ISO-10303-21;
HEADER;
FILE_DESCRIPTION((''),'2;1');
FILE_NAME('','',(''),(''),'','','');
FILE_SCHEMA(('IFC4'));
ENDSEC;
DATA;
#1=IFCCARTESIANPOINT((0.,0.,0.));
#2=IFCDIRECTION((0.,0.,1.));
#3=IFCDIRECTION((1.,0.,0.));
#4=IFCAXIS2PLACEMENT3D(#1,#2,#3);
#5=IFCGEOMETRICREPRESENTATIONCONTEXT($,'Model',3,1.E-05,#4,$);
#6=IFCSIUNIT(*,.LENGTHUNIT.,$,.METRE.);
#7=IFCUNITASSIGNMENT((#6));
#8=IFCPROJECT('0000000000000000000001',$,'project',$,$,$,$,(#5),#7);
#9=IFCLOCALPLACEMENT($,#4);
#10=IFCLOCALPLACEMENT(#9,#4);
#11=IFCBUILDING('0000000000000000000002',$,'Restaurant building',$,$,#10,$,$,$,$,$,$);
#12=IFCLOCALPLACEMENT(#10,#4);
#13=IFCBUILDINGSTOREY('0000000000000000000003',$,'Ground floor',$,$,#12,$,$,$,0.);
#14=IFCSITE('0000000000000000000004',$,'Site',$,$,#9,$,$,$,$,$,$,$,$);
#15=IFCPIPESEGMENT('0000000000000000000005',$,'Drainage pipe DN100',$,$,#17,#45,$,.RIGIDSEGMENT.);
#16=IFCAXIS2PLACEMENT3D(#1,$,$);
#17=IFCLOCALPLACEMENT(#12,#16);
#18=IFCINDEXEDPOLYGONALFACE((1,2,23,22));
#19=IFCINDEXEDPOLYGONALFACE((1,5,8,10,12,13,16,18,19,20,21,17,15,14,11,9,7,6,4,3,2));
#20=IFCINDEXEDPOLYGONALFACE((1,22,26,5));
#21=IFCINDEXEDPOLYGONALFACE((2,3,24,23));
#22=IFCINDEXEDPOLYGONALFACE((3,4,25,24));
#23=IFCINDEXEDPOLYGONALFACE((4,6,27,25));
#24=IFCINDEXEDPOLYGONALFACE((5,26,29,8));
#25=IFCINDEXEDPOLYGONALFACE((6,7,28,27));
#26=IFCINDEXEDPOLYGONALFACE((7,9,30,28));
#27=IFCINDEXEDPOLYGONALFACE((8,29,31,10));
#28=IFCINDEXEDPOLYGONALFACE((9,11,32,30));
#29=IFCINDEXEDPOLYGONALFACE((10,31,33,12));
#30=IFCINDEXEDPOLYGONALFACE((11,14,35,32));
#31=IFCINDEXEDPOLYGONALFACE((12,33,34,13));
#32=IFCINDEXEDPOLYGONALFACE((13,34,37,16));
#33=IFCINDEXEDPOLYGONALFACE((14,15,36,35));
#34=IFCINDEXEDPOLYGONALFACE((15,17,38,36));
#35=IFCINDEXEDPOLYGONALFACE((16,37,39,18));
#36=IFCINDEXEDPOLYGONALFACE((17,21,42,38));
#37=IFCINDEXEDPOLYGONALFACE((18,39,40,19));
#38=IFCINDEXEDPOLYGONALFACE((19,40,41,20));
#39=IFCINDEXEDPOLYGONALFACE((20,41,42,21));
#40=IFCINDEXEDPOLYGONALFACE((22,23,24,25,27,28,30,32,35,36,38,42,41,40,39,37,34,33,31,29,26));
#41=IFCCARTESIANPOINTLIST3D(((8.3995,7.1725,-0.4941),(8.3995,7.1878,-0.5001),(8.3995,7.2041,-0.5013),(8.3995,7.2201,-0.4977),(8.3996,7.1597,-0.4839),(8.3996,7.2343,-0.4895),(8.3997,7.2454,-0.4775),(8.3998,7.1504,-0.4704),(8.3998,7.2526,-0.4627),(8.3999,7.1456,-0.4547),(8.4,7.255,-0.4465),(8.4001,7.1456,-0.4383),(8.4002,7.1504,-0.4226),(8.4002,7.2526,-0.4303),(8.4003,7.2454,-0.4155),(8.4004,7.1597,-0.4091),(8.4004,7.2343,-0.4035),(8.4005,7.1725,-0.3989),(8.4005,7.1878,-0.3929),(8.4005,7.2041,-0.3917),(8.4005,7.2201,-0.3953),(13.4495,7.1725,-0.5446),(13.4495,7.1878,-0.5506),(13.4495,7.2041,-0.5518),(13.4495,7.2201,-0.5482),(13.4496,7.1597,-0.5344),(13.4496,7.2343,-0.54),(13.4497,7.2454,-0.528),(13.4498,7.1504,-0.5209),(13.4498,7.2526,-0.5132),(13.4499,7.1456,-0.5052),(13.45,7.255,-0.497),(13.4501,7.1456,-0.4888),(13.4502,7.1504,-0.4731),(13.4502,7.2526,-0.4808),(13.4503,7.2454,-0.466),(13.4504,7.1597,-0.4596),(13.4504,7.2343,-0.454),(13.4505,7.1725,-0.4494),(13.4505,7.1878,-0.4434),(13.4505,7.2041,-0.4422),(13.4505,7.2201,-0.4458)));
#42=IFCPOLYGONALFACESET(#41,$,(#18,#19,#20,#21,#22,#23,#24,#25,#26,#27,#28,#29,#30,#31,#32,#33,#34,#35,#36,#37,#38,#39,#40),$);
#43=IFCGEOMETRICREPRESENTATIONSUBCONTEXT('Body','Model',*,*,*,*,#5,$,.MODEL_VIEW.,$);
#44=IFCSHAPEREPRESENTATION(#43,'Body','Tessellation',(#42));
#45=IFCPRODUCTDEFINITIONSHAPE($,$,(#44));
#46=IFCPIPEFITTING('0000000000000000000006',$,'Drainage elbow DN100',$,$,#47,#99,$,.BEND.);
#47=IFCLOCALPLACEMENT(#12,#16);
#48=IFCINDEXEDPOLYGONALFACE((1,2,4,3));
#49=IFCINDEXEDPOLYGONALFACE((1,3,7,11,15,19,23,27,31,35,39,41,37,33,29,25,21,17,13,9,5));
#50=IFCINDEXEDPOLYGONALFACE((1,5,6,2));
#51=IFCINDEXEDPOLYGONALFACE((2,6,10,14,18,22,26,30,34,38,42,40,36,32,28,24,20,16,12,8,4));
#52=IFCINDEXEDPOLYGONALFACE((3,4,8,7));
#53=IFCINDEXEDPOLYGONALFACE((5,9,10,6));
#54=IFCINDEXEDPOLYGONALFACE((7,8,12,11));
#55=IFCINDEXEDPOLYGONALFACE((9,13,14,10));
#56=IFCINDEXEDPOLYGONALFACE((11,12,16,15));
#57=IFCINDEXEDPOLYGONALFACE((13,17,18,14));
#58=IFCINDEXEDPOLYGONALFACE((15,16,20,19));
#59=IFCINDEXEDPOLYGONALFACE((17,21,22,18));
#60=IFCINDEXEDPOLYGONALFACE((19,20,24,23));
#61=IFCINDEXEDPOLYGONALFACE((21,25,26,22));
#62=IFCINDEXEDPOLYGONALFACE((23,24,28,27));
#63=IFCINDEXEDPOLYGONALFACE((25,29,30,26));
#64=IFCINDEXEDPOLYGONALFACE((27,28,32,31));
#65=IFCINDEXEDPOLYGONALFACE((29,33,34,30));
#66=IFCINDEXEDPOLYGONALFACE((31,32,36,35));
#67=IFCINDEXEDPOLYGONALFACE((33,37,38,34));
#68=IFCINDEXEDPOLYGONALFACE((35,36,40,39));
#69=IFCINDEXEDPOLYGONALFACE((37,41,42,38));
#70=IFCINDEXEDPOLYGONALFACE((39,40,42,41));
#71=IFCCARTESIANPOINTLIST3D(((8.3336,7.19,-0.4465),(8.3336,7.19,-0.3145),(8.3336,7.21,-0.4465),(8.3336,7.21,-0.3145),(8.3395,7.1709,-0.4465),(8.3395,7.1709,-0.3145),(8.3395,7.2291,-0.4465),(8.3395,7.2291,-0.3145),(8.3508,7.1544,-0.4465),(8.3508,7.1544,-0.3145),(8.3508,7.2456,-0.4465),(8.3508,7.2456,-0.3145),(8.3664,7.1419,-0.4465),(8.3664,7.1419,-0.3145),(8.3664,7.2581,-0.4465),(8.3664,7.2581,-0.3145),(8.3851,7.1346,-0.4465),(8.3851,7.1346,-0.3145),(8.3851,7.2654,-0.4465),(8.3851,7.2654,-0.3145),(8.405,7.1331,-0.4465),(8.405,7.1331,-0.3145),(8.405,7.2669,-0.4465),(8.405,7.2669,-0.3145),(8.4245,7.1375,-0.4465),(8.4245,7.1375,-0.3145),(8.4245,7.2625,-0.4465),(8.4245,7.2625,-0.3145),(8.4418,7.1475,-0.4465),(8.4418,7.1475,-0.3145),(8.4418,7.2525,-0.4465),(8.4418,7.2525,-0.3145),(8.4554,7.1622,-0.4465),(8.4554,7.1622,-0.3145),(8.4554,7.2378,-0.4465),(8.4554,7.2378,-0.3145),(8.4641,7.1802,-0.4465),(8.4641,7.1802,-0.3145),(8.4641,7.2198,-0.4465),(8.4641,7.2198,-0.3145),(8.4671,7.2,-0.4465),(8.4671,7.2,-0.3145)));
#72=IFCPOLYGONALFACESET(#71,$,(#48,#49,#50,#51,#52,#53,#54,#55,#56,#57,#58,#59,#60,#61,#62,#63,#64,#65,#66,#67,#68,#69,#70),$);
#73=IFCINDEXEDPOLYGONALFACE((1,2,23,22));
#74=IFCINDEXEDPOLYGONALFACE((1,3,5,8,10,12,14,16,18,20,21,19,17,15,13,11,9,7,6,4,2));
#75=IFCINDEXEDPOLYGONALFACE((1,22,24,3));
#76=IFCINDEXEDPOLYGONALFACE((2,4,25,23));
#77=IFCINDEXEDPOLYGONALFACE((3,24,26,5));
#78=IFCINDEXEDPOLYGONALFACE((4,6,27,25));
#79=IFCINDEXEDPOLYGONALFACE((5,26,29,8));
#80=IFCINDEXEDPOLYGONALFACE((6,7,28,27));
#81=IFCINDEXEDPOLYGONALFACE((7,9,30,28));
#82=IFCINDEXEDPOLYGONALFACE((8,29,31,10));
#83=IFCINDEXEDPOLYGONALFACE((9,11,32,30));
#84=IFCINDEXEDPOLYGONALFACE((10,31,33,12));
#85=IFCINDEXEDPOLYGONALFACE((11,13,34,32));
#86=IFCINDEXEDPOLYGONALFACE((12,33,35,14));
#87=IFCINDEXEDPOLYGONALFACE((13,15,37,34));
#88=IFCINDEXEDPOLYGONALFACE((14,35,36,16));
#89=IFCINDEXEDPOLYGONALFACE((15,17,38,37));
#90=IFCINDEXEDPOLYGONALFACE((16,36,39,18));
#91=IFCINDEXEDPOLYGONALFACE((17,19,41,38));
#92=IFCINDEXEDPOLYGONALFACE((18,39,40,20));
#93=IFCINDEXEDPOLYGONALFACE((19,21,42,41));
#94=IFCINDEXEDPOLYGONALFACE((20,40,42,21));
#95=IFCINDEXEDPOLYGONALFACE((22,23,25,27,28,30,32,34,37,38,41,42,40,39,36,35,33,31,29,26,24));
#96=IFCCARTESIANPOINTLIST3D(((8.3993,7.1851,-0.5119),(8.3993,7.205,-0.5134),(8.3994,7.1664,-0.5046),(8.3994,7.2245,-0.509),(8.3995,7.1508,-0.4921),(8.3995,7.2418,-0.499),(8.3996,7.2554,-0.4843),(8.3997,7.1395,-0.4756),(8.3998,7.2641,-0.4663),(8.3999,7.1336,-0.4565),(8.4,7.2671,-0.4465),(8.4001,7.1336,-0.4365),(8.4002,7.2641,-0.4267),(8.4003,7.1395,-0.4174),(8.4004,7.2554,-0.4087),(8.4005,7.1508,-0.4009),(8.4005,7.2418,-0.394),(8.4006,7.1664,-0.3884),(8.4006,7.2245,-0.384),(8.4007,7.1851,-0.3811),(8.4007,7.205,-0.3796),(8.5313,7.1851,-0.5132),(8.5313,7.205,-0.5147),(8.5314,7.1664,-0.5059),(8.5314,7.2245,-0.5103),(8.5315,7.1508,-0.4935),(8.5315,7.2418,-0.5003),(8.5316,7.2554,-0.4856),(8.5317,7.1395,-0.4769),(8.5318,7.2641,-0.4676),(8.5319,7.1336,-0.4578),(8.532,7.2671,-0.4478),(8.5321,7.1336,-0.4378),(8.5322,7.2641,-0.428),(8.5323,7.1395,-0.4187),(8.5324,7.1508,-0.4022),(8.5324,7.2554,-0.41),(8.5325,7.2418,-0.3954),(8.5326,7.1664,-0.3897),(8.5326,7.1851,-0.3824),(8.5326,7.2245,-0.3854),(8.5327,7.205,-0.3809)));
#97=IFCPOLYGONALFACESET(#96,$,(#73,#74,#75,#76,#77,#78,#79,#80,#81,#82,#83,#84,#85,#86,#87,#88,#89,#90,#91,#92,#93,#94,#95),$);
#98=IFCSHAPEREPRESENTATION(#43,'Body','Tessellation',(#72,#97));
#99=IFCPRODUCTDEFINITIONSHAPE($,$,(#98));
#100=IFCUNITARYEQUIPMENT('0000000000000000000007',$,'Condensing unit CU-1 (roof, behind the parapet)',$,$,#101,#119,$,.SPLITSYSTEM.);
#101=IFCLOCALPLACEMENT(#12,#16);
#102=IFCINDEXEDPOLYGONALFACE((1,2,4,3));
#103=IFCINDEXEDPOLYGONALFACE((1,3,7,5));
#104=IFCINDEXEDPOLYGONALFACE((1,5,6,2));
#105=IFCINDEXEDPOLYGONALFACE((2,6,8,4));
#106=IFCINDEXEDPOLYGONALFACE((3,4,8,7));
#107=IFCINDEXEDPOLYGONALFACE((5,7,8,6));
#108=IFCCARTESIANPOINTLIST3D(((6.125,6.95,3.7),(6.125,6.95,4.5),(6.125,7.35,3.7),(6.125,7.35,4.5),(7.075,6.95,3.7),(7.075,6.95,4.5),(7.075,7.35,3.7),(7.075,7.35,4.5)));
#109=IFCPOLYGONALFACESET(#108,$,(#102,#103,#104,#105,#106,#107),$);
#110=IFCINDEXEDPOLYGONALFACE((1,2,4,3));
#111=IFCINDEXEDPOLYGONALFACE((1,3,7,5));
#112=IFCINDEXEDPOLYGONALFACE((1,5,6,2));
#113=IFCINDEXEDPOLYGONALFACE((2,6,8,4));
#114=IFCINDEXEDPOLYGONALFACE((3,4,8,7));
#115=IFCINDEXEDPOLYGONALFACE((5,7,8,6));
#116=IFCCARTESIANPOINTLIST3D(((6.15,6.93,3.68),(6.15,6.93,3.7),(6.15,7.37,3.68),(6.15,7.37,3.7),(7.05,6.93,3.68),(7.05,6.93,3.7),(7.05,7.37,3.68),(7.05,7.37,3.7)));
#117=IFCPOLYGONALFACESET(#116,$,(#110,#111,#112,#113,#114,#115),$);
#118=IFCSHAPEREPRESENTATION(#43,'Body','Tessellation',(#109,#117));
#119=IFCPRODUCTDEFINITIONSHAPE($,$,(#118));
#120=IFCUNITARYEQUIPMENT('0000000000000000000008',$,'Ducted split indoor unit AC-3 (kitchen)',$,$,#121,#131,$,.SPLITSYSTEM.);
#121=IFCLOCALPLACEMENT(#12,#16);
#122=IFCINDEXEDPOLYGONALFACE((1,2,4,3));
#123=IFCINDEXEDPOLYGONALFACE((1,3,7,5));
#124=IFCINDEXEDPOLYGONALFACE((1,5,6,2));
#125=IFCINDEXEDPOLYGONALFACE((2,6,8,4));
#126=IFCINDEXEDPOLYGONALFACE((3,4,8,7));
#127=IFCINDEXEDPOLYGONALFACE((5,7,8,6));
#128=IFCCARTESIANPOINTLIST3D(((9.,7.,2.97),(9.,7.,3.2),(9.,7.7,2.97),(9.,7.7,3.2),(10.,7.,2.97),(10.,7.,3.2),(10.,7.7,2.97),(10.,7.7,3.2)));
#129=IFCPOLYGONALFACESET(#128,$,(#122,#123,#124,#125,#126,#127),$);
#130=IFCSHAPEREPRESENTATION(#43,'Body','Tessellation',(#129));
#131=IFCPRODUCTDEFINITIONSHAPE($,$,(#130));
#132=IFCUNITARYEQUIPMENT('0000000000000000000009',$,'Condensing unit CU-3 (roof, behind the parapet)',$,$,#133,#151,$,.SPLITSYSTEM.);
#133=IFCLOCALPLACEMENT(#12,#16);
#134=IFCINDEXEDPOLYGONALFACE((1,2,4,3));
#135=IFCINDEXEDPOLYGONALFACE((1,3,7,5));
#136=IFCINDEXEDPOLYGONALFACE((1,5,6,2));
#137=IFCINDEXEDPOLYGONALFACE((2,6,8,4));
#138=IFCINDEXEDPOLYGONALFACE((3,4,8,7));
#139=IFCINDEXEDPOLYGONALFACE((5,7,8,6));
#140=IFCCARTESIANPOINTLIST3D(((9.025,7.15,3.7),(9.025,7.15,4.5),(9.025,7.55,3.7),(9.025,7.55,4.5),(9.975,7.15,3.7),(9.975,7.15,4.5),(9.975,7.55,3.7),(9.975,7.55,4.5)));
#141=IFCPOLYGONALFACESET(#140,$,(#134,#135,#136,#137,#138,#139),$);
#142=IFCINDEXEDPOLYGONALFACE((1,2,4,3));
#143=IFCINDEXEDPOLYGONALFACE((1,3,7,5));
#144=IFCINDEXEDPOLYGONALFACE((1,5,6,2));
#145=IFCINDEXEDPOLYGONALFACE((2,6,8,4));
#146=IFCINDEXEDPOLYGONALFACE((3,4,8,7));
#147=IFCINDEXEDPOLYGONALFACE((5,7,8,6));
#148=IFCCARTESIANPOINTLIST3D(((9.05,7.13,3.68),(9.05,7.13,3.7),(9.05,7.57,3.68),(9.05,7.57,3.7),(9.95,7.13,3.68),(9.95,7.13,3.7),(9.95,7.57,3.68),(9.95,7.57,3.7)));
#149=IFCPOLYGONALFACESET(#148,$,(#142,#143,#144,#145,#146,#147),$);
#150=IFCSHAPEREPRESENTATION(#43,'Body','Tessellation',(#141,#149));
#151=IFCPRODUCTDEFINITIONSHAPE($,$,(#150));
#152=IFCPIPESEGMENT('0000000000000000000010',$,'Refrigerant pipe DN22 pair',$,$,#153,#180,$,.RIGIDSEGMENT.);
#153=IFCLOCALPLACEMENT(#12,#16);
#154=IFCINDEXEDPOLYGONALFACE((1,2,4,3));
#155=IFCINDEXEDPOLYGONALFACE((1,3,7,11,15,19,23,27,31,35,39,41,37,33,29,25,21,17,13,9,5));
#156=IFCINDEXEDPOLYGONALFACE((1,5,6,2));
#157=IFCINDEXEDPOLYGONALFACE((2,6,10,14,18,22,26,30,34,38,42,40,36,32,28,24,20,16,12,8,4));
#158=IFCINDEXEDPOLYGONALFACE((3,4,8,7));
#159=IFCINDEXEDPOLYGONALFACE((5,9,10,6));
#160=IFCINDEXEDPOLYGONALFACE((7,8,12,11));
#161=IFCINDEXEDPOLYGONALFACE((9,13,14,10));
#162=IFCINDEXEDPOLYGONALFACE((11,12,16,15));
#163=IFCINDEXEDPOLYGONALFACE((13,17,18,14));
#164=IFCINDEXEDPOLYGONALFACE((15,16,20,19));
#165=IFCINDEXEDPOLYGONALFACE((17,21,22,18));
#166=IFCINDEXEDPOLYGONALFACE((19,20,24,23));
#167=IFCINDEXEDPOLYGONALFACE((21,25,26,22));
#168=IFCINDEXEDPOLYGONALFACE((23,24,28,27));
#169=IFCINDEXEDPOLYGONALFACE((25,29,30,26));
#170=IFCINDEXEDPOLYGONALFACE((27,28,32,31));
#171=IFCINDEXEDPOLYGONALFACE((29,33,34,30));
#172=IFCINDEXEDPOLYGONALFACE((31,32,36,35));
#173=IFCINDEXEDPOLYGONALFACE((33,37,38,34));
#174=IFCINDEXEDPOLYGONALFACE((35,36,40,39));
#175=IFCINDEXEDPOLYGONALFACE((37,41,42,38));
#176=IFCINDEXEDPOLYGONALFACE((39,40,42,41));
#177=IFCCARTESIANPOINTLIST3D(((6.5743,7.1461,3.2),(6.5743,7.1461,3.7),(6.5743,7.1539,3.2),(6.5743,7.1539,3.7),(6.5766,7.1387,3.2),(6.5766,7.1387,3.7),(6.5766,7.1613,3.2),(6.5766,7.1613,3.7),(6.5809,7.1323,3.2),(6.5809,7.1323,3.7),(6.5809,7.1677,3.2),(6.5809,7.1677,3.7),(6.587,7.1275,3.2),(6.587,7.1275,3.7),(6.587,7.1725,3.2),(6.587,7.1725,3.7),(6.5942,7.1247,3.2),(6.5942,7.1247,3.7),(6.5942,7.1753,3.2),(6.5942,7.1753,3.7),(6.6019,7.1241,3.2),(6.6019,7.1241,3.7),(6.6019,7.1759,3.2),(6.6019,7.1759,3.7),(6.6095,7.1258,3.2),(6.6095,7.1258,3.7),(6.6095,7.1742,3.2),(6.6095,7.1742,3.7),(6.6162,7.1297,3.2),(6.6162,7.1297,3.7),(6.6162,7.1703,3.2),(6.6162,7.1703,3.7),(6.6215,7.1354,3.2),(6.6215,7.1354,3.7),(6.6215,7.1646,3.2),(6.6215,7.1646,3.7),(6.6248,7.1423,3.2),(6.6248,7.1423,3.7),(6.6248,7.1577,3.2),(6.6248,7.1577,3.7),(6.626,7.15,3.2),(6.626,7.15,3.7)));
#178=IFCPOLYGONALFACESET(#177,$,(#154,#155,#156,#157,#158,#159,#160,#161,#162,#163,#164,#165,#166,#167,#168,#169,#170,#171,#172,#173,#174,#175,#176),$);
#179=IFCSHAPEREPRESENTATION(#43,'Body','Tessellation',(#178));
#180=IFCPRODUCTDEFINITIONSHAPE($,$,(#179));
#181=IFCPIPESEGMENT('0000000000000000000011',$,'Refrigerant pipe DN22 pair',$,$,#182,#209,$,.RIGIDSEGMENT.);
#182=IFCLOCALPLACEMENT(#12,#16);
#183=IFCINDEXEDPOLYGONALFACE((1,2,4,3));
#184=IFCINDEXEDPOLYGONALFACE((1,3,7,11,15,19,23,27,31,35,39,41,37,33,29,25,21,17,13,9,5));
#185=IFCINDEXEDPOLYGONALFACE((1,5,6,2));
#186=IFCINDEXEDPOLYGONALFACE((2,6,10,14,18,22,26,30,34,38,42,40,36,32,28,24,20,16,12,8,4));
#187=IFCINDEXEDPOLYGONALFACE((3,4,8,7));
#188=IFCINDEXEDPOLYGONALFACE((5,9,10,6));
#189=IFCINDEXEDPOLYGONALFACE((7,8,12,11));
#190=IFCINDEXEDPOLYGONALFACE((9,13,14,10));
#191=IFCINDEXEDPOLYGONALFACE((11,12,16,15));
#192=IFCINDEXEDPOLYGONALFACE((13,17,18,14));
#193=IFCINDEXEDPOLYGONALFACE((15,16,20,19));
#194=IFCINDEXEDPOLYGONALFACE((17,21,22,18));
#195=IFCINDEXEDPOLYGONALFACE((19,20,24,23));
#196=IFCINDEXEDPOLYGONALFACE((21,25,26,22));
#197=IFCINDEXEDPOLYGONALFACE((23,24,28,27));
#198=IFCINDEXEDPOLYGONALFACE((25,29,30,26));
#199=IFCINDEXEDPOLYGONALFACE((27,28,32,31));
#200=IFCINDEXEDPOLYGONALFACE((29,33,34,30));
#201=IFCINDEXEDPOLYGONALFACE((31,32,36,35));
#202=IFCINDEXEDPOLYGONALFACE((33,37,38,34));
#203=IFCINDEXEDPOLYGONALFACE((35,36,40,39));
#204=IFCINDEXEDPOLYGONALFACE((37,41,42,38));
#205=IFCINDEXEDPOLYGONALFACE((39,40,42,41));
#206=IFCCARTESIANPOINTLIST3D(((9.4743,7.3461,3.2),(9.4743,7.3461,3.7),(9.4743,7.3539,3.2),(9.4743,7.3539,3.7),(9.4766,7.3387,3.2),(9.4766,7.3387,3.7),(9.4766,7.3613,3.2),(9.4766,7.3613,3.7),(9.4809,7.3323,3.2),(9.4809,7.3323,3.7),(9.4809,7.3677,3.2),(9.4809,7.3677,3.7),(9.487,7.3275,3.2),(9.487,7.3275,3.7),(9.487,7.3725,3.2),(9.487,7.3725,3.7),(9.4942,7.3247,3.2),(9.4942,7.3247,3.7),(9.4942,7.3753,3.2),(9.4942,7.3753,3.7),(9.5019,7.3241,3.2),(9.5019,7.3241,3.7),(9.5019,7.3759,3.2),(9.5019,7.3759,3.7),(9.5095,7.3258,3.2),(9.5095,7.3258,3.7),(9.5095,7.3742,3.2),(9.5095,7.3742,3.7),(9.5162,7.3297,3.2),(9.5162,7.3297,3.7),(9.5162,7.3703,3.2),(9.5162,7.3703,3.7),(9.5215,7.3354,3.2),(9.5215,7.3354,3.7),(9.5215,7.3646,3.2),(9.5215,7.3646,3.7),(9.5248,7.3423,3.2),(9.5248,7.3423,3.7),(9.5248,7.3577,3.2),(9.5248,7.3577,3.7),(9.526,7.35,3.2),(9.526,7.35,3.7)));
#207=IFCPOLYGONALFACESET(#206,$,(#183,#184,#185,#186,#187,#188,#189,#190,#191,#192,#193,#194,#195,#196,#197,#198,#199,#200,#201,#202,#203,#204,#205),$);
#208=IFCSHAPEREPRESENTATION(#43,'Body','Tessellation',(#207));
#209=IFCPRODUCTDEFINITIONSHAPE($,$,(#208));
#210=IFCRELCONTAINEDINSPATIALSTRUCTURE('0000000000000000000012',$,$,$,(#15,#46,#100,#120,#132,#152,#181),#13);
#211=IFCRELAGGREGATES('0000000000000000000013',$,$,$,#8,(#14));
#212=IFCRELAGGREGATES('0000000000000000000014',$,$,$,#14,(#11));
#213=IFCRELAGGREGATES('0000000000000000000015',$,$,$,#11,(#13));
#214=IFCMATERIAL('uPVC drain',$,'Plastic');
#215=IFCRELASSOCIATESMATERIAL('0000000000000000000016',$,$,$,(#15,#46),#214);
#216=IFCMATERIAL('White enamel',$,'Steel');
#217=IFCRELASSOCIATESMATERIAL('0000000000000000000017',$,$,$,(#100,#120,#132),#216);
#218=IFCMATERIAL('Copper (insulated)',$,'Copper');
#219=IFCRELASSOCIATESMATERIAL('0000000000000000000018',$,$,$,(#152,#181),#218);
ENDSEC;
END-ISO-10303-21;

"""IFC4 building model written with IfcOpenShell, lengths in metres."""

from ifc_helpers import new_model, si_unit, frame, origin, origin_with_axes, origin_2d, place, context, subcontext, project, spatial, rectangle, circle, extrude, material, element, save


model = new_model("IFC4")

# Units and contexts
model_context = context("Model", 3, precision=1e-05, world=origin_with_axes())
body_context = subcontext(model_context, "Body", "Model", "MODEL_VIEW")
ifc_project = project(units=[si_unit("LENGTHUNIT", "METRE")], contexts=[model_context])

# Site, building, storey
site_placement = place(None, origin_with_axes())
site = spatial("IfcSite", under=ifc_project, at=site_placement, Name="Site")
building_placement = place(site_placement, origin_with_axes())
building = spatial("IfcBuilding", under=site, at=building_placement, Name="Restaurant building")
storey_placement = place(building_placement, origin_with_axes())
storey = spatial("IfcBuildingStorey", under=building, at=storey_placement, Name="Ground floor", Elevation=0.0)

# Shared definitions
ifc_material_1 = material(Name="White enamel", Category="Steel")

# Pipe segment
ifc_material_2 = material(Name="uPVC drain", Category="Plastic")
pipe_segment_1_placement = place(storey_placement, frame((8.4, 7.2, -0.4465)))
element("IfcPipeSegment", 1, at=pipe_segment_1_placement, inside=storey, material=ifc_material_2, Name="Drainage pipe DN100", PredefinedType="RIGIDSEGMENT", context=body_context, shape_type="SweptSolid", body=[
    extrude(circle(Radius=0.055, at=origin_2d()), frame((0.0, 0.0, 0.0), z_axis=(0.99995, 0.0, -0.009999), x_axis=(0.0, 1.0, 0.0)), (0.0, 0.0, 1.0), 5.0503),
])

# Pipe fitting
pipe_fitting_1_placement = place(storey_placement, frame((8.4, 7.2, -0.4465)))
element("IfcPipeFitting", 2, at=pipe_fitting_1_placement, inside=storey, material=ifc_material_2, Name="Drainage elbow DN100", PredefinedType="BEND", context=body_context, shape_type="SweptSolid", body=[
    extrude(circle(Radius=0.0671, at=origin_2d()), origin(), (0.0, 0.0, 1.0), 0.132),
    extrude(circle(Radius=0.0671, at=origin_2d()), frame((0.0, 0.0, 0.0), z_axis=(0.99995, 0.0, -0.009999), x_axis=(0.0, 1.0, 0.0)), (0.0, 0.0, 1.0), 0.132),
])

# Unitary equipment
unitary_equipment_1_placement = place(storey_placement, frame((6.6, 7.15, 0.0)))
element("IfcUnitaryEquipment", 3, at=unitary_equipment_1_placement, inside=storey, material=ifc_material_1, Name="Condensing unit CU-1 (roof, behind the parapet)", PredefinedType="SPLITSYSTEM", context=body_context, shape_type="SweptSolid", body=[
    extrude(rectangle(XDim=0.95, YDim=0.4, at=origin_2d()), frame((0.0, 0.0, 3.7)), (0.0, 0.0, 1.0), 0.8),
    extrude(rectangle(XDim=0.9, YDim=0.44, at=origin_2d()), frame((0.0, 0.0, 3.68)), (0.0, 0.0, 1.0), 0.02),
])
unitary_equipment_2_placement = place(storey_placement, frame((9.5, 7.35, 0.0)))
element("IfcUnitaryEquipment", 4, at=unitary_equipment_2_placement, inside=storey, material=ifc_material_1, Name="Ducted split indoor unit AC-3 (kitchen)", PredefinedType="SPLITSYSTEM", context=body_context, shape_type="SweptSolid", body=[
    extrude(rectangle(XDim=1.0, YDim=0.7, at=origin_2d()), frame((0.0, 0.0, 2.97)), (0.0, 0.0, 1.0), 0.23),
])
unitary_equipment_3_placement = place(storey_placement, frame((9.5, 7.35, 0.0)))
element("IfcUnitaryEquipment", 5, at=unitary_equipment_3_placement, inside=storey, material=ifc_material_1, Name="Condensing unit CU-3 (roof, behind the parapet)", PredefinedType="SPLITSYSTEM", context=body_context, shape_type="SweptSolid", body=[
    extrude(rectangle(XDim=0.95, YDim=0.4, at=origin_2d()), frame((0.0, 0.0, 3.7)), (0.0, 0.0, 1.0), 0.8),
    extrude(rectangle(XDim=0.9, YDim=0.44, at=origin_2d()), frame((0.0, 0.0, 3.68)), (0.0, 0.0, 1.0), 0.02),
])

# Pipe segments
ifc_material_3 = material(Name="Copper (insulated)", Category="Copper")
for number, where, name in (
    (6, (6.6, 7.15, 3.7), "Refrigerant pipe DN22 pair"),
    (7, (9.5, 7.35, 3.7), "Refrigerant pipe DN22 pair"),
):
    element("IfcPipeSegment", number, at=place(storey_placement, frame(where)), inside=storey, material=ifc_material_3, Name=name, PredefinedType="RIGIDSEGMENT", context=body_context, shape_type="SweptSolid", body=[
        extrude(circle(Radius=0.026, at=origin_2d()), frame((0.0, 0.0, 0.0), z_axis=(0.0, 0.0, -1.0), x_axis=(1.0, 0.0, 0.0)), (0.0, 0.0, 1.0), 0.5),
    ])

save(model, "model.ifc")
